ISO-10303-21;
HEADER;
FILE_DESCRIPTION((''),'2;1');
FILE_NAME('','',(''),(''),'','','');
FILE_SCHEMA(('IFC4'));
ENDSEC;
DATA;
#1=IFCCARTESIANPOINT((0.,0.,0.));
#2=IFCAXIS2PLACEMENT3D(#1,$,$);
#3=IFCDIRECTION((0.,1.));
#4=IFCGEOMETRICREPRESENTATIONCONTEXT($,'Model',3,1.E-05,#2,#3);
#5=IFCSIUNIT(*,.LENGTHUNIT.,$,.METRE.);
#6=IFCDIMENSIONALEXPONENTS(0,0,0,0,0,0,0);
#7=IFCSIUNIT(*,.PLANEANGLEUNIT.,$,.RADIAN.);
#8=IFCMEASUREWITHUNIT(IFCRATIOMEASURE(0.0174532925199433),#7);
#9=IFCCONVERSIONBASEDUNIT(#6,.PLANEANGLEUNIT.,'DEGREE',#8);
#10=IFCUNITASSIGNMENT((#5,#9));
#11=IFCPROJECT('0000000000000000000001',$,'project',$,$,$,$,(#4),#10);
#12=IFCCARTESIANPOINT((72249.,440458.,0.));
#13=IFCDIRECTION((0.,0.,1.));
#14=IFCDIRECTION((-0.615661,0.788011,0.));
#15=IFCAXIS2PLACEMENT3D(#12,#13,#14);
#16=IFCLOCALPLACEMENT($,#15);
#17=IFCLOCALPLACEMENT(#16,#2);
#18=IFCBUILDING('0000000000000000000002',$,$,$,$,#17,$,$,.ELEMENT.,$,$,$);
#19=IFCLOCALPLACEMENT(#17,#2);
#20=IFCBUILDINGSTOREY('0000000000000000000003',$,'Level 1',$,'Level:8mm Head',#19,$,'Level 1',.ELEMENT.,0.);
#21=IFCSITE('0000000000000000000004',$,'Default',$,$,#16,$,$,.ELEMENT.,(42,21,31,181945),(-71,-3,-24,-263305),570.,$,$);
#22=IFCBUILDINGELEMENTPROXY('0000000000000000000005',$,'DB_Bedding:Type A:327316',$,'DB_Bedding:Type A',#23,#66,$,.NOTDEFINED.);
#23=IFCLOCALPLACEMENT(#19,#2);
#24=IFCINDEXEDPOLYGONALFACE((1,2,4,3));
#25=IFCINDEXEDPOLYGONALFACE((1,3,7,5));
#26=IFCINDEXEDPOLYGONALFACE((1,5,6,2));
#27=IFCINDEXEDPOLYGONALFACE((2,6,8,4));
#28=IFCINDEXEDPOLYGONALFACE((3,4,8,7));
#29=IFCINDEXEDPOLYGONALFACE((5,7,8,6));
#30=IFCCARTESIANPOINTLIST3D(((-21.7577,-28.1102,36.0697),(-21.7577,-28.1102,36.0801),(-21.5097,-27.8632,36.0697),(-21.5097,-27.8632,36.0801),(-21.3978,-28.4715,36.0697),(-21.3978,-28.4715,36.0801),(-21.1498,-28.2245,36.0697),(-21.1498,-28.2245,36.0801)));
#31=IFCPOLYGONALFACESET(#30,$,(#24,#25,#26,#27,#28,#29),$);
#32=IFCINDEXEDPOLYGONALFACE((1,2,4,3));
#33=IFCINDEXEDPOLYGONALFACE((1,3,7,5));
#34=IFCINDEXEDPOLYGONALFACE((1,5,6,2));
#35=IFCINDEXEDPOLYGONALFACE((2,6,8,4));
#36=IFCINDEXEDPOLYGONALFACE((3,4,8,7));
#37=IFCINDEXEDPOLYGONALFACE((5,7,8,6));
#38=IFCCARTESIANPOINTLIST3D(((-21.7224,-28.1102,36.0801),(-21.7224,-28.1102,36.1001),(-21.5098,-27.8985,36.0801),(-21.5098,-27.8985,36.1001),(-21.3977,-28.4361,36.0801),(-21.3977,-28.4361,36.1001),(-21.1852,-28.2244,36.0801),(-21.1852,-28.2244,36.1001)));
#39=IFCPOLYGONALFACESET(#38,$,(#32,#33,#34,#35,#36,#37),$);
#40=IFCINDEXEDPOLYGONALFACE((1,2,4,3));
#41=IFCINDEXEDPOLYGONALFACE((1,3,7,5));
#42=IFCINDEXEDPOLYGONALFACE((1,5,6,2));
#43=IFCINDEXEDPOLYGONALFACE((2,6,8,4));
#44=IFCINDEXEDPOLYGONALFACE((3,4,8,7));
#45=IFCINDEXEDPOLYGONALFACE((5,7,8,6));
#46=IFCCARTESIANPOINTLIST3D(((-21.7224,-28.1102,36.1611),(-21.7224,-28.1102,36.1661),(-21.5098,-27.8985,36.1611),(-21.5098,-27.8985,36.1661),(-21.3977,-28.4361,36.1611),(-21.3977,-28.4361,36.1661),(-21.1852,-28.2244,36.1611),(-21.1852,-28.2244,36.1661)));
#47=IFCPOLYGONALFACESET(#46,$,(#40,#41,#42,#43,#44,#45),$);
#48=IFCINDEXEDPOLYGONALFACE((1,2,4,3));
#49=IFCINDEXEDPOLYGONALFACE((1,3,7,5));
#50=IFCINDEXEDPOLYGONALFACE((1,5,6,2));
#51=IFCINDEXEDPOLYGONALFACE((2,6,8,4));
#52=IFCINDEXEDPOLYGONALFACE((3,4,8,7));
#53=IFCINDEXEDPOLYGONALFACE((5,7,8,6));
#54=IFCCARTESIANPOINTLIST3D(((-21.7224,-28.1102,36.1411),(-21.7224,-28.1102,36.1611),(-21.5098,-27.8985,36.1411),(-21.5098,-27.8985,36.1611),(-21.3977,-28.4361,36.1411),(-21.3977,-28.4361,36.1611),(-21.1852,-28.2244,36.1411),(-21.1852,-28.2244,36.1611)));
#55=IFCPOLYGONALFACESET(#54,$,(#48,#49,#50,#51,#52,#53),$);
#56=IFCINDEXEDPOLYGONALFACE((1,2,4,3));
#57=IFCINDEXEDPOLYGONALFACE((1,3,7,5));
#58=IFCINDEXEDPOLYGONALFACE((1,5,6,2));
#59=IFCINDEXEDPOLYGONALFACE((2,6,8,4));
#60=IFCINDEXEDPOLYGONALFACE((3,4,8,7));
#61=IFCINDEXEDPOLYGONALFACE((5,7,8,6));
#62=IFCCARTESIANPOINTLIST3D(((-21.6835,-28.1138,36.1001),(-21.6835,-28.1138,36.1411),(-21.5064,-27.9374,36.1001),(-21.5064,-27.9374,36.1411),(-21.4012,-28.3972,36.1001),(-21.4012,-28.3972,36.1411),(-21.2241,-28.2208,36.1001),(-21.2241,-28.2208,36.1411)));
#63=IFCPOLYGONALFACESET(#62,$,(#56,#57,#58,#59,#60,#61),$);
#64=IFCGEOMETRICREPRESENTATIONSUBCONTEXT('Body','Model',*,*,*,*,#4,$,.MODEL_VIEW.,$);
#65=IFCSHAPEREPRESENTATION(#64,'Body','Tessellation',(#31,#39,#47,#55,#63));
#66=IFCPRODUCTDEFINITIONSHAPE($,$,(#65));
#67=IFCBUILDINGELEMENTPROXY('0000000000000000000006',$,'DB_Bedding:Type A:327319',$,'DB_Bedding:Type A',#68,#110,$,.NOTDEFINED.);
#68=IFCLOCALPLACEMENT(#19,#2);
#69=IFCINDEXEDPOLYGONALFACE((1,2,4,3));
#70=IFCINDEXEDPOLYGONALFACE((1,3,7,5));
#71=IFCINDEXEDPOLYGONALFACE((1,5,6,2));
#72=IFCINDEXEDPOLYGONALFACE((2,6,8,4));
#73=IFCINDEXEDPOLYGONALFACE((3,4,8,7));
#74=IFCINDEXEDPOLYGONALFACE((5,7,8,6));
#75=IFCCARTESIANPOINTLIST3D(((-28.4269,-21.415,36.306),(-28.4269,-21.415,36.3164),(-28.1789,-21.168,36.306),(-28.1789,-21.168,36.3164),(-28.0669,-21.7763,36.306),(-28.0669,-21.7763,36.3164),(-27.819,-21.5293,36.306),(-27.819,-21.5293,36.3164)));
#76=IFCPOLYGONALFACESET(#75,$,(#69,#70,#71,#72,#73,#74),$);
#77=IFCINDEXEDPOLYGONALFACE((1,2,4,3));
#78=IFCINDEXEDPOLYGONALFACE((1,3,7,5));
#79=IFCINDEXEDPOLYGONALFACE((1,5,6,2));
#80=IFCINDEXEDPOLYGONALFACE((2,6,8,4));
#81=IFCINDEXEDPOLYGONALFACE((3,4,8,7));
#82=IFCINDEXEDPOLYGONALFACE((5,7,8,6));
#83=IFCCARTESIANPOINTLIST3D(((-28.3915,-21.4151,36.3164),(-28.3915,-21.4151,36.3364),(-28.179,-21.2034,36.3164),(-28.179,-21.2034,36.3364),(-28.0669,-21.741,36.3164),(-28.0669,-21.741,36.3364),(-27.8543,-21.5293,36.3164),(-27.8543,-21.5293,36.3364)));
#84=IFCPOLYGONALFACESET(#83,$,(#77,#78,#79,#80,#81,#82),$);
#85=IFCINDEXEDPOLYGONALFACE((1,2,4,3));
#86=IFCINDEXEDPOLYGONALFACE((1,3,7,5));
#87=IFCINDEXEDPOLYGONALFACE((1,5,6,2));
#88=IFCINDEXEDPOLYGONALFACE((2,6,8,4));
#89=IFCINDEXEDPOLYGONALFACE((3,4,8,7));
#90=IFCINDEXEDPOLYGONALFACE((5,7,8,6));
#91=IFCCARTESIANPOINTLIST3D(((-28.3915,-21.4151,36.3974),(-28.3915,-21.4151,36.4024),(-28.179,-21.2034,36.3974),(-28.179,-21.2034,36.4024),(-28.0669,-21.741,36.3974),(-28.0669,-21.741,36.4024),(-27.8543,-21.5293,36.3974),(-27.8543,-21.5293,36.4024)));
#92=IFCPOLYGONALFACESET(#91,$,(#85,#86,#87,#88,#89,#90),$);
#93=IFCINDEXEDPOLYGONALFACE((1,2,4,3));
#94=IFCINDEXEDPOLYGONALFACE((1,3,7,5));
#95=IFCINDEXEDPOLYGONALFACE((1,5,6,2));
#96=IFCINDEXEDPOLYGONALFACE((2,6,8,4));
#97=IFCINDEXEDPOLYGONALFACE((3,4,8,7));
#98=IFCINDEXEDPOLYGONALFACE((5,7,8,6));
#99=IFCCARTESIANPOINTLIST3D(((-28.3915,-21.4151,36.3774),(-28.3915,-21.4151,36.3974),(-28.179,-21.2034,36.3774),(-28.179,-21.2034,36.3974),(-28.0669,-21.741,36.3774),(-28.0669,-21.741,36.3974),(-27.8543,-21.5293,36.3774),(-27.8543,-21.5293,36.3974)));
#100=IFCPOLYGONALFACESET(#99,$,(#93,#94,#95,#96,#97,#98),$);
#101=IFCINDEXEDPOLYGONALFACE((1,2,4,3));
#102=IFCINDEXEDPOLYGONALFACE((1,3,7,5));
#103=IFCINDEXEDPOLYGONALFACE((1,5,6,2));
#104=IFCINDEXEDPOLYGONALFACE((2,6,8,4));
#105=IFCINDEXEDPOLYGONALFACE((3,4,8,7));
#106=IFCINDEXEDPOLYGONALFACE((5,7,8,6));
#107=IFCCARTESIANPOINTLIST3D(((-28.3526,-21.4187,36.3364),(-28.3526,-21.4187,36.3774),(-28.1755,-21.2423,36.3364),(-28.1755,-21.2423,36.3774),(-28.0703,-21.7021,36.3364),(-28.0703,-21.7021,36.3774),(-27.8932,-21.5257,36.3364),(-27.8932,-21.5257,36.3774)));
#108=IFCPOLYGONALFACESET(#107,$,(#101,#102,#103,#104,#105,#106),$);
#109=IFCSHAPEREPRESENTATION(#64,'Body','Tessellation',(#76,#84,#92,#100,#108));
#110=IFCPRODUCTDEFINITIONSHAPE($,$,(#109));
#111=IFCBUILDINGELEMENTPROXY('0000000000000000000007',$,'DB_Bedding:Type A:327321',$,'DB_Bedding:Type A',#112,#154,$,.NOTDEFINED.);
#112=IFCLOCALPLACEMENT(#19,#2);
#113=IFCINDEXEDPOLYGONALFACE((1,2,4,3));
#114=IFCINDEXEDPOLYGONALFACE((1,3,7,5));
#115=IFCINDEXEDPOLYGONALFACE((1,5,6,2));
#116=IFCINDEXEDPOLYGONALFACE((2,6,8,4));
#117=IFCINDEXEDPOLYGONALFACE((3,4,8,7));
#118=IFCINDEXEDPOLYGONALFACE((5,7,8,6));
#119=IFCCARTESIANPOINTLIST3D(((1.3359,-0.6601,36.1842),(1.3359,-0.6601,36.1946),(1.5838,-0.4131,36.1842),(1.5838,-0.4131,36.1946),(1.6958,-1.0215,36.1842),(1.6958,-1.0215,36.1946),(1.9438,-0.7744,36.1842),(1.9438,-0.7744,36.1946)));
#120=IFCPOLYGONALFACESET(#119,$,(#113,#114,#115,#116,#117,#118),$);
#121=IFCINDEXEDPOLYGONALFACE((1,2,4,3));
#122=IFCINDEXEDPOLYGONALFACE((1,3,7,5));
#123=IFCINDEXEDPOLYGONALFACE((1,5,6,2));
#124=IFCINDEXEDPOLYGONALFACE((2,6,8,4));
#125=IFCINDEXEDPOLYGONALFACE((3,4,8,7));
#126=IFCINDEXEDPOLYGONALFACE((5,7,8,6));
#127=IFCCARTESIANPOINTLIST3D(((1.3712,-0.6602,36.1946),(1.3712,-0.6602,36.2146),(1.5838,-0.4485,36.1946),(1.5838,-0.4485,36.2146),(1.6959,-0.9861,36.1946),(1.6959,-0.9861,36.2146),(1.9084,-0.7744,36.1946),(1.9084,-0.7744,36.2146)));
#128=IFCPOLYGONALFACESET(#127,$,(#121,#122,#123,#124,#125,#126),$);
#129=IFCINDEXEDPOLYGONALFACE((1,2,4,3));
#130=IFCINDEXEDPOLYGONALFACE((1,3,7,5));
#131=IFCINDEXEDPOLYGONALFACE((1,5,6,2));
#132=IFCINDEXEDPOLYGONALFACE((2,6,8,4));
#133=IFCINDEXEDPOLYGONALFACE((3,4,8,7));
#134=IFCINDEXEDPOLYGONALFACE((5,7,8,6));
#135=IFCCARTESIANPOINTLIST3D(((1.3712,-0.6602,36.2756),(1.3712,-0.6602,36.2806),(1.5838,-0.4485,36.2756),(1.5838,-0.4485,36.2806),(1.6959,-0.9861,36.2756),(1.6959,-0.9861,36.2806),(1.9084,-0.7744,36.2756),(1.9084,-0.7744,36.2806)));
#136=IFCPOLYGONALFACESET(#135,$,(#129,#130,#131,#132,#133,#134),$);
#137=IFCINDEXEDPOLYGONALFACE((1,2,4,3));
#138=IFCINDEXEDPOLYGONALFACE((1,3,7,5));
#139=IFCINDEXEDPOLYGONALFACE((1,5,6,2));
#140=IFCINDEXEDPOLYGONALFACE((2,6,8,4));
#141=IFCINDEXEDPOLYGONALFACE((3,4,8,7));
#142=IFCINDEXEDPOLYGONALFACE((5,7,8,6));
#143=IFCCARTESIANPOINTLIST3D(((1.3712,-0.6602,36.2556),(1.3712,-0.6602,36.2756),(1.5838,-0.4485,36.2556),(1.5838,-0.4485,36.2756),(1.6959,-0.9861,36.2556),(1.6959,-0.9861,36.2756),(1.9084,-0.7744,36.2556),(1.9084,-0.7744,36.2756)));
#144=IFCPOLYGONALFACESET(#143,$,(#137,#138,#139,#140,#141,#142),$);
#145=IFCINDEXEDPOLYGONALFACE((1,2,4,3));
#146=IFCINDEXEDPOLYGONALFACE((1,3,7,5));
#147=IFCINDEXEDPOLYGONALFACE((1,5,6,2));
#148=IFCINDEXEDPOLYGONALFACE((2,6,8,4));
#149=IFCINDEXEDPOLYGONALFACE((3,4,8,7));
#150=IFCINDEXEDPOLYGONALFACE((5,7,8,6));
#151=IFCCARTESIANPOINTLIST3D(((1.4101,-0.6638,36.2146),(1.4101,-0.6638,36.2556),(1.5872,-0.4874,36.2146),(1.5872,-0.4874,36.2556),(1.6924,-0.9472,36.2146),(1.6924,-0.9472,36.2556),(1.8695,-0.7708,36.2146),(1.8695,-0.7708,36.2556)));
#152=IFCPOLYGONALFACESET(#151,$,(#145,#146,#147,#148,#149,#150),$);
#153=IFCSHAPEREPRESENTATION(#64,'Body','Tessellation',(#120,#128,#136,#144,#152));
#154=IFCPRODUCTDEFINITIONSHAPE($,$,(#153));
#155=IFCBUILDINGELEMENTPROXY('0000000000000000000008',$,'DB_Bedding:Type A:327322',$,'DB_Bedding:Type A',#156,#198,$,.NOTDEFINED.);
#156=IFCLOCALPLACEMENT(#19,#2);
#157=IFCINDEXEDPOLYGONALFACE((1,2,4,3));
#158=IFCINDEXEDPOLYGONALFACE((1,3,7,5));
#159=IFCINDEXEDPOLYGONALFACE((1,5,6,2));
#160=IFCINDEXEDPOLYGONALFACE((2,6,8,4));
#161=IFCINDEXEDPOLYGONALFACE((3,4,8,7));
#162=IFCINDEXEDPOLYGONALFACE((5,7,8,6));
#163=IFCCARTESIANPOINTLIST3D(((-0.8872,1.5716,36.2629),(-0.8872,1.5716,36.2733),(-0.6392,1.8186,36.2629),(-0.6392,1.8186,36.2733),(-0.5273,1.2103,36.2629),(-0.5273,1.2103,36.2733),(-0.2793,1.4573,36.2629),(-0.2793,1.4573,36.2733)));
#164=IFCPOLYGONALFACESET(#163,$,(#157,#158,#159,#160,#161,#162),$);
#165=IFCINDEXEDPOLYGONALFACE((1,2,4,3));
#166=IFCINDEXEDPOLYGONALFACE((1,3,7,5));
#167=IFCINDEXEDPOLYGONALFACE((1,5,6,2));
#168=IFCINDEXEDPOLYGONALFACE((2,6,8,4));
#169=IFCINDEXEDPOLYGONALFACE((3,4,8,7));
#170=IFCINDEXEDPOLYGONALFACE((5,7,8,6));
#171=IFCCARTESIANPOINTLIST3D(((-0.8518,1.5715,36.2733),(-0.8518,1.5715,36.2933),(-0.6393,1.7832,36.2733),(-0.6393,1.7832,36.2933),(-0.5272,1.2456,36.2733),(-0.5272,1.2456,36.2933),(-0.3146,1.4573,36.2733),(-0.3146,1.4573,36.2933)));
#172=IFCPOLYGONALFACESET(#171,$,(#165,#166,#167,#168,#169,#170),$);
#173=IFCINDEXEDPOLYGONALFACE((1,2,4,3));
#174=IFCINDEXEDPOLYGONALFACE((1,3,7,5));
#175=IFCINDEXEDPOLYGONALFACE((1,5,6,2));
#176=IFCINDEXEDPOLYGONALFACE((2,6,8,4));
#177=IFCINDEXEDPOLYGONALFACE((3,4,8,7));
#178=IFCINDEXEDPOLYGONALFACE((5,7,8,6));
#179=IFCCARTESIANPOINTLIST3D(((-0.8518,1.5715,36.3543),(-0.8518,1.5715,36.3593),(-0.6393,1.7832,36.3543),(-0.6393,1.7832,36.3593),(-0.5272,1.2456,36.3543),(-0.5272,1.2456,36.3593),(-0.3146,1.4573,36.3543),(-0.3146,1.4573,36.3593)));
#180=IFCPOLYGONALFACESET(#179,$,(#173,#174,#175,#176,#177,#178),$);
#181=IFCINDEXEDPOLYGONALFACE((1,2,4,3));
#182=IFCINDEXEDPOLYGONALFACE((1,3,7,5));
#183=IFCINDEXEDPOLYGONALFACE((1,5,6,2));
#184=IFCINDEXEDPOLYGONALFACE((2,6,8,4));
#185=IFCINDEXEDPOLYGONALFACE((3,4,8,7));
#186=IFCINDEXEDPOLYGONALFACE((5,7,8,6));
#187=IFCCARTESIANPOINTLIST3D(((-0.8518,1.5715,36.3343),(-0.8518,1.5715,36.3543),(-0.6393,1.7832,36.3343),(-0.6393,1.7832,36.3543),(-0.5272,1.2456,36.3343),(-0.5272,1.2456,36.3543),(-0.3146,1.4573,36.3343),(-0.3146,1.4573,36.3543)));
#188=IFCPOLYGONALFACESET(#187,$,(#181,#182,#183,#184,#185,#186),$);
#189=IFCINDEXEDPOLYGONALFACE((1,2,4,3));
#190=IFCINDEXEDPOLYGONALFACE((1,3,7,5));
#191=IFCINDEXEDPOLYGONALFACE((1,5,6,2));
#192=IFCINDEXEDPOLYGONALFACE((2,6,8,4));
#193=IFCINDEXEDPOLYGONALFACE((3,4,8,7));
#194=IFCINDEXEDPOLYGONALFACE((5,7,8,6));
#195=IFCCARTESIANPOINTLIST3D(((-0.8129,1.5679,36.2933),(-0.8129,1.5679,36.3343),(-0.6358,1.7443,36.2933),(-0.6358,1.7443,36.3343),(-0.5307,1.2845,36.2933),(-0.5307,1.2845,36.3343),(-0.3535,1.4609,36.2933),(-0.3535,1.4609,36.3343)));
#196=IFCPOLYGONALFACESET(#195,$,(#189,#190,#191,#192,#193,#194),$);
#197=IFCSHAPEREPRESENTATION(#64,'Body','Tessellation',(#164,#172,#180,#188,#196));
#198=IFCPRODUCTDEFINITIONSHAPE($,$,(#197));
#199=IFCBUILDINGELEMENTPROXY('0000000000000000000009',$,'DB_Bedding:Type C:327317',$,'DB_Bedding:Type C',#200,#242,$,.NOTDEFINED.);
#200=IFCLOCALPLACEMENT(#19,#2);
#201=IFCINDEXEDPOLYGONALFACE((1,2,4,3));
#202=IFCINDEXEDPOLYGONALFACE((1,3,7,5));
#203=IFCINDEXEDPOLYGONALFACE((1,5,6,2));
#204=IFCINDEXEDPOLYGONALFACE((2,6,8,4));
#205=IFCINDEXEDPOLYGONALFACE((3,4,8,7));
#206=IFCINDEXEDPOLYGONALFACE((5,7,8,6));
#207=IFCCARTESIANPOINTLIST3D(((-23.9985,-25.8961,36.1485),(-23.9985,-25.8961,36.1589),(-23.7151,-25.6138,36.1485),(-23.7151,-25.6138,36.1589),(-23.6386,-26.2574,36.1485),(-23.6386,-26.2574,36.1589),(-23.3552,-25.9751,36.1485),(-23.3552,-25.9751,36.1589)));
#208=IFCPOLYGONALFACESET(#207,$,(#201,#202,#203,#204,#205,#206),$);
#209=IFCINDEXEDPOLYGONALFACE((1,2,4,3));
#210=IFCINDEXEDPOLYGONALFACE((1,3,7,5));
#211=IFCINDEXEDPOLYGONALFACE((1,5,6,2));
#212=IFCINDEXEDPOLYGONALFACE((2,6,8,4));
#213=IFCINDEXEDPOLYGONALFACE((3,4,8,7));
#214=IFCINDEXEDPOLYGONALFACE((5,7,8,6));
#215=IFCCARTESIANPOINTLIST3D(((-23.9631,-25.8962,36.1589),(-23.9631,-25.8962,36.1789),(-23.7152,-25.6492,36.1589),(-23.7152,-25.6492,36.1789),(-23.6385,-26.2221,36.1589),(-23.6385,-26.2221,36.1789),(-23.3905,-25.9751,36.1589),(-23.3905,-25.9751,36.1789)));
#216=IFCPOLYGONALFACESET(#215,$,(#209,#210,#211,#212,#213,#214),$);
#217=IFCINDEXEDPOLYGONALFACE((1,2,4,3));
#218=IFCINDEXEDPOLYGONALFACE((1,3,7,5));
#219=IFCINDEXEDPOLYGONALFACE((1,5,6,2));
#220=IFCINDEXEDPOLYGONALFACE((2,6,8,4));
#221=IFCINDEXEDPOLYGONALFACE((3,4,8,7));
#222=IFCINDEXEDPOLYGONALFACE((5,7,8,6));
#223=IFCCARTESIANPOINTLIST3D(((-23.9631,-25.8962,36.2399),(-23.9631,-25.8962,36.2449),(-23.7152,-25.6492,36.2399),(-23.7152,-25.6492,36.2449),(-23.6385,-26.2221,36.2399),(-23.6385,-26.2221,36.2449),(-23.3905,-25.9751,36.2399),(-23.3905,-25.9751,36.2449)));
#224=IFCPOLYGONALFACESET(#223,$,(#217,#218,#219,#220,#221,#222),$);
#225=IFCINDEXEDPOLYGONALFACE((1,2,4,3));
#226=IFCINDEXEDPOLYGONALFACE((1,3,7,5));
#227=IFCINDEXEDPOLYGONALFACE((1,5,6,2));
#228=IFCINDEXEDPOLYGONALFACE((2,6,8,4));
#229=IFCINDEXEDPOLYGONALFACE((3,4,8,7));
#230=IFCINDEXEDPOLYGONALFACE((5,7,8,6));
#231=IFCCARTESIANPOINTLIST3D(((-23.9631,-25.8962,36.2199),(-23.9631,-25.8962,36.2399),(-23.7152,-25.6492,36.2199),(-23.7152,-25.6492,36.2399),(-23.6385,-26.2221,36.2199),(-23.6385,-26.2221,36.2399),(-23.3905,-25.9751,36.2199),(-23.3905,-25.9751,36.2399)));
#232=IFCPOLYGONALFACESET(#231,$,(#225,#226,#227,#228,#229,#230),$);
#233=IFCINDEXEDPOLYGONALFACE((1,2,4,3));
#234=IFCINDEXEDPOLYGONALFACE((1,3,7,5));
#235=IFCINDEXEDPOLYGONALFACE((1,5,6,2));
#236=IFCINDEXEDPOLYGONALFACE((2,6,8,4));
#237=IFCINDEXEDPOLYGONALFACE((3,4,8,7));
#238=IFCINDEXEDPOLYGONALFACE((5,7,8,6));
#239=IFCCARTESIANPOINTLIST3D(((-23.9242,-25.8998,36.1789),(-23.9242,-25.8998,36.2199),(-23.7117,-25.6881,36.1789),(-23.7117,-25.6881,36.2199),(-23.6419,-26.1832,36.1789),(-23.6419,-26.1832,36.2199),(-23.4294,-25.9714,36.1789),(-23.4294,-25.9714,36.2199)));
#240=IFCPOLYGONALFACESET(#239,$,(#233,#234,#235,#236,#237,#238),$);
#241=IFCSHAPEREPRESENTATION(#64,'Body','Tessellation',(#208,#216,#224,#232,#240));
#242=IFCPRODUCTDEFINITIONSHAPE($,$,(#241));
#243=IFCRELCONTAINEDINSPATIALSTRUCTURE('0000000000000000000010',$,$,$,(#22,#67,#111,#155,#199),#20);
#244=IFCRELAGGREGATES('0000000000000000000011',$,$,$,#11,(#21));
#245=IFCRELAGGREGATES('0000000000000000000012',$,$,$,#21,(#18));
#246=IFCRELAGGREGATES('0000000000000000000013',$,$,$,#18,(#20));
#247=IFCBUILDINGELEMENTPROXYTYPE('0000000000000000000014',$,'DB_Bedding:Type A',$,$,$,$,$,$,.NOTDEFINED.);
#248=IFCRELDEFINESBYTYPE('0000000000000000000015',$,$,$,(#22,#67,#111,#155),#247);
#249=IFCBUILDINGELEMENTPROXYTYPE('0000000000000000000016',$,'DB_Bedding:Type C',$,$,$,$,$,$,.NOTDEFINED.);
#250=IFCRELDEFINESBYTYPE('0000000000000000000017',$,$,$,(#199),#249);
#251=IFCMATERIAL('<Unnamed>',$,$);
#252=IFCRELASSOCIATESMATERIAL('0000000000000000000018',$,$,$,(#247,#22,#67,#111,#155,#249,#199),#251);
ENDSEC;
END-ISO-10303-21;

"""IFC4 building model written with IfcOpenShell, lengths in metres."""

from ifc_helpers import new_model, entity, si_unit, converted_unit, direction, frame, origin, origin_2d_with_axis, place, context, subcontext, project, spatial, rectangle, extrude, source, transform, mapped, material, type_object, type_shapes, element, save


model = new_model("IFC4")

# Units and contexts
model_context = context("Model", 3, precision=1e-05, world=origin(), true_north=direction((0.0, 1.0)))
body_context = subcontext(model_context, "Body", "Model", "MODEL_VIEW")
ifc_project = project(units=[si_unit("LENGTHUNIT", "METRE"), converted_unit("PLANEANGLEUNIT", "DEGREE", entity("IfcRatioMeasure", 0.0174532925199433), si_unit("PLANEANGLEUNIT", "RADIAN"), dimensions=[0, 0, 0, 0, 0, 0, 0])], contexts=[model_context])

# Site, building, storey
site_placement = place(None, frame((72249.0, 440458.0, 0.0), z_axis=(0.0, 0.0, 1.0), x_axis=(-0.615661, 0.788011, 0.0)))
site = spatial("IfcSite", under=ifc_project, at=site_placement, Name="Default", CompositionType="ELEMENT", RefLatitude=(42, 21, 31, 181945), RefLongitude=(-71, -3, -24, -263305), RefElevation=570.0)
building_placement = place(site_placement, origin())
building = spatial("IfcBuilding", under=site, at=building_placement, CompositionType="ELEMENT")
storey_placement = place(building_placement, origin())
storey = spatial("IfcBuildingStorey", under=building, at=storey_placement, Name="Level 1", ObjectType="Level:8mm Head", LongName="Level 1", CompositionType="ELEMENT", Elevation=0.0)

# Building element proxies
ifc_material = material(Name="<Unnamed>")
building_element_proxy_type_1 = type_object("IfcBuildingElementProxyType", Name="DB_Bedding:Type A", PredefinedType="NOTDEFINED", material=ifc_material)
shared_shape_1 = source(origin(), body_context, "Body", "SweptSolid", [
    extrude(rectangle(XDim=0.35, YDim=0.51, at=origin_2d_with_axis()), frame((0.0, 0.0, -0.0965), z_axis=(0.0, 0.0, 1.0), x_axis=(0.0, 1.0, 0.0)), (0.0, 0.0, 1.0), 0.0105),
    extrude(rectangle(XDim=0.3, YDim=0.46, at=origin_2d_with_axis()), frame((0.0, 0.0, -0.086), z_axis=(0.0, 0.0, 1.0), x_axis=(0.0, 1.0, 0.0)), (0.0, 0.0, 1.0), 0.02),
    extrude(rectangle(XDim=0.3, YDim=0.46, at=origin_2d_with_axis()), frame((0.0, 0.0, -0.005), z_axis=(0.0, 0.0, 1.0), x_axis=(0.0, 1.0, 0.0)), (0.0, 0.0, 1.0), 0.005),
    extrude(rectangle(XDim=0.3, YDim=0.46, at=origin_2d_with_axis()), frame((0.0, 0.0, -0.025), z_axis=(0.0, 0.0, 1.0), x_axis=(0.0, 1.0, 0.0)), (0.0, 0.0, 1.0), 0.02),
    extrude(rectangle(XDim=0.25, YDim=0.4, at=origin_2d_with_axis()), frame((0.0, 0.0, -0.066), z_axis=(0.0, 0.0, 1.0), x_axis=(0.0, 1.0, 0.0)), (0.0, 0.0, 1.0), 0.041),
])
type_shapes(building_element_proxy_type_1, [shared_shape_1])
for number, where, z_axis, x_axis, name in (
    (1, (-21.4538, -28.1673, 36.1661), (0.0, 0.0, 1.0), (0.70573, -0.708481, 0.0), "DB_Bedding:Type A:327316"),
    (2, (-28.1229, -21.4722, 36.4024), (0.0, 0.0, 1.0), (0.70573, -0.708481, 0.0), "DB_Bedding:Type A:327319"),
    (3, (1.6398, -0.7173, 36.2806), (0.0, 0.0, 1.0), (0.70573, -0.708481, 0.0), "DB_Bedding:Type A:327321"),
    (4, (-0.5832, 1.5144, 36.3593), (0.0, 0.0, 1.0), (0.70573, -0.708481, 0.0), "DB_Bedding:Type A:327322"),
):
    element("IfcBuildingElementProxy", number, at=place(storey_placement, frame(where, z_axis=z_axis, x_axis=x_axis)), inside=storey, type_object=building_element_proxy_type_1, material=ifc_material, Name=name, ObjectType="DB_Bedding:Type A", PredefinedType="NOTDEFINED", context=body_context, shape_type="MappedRepresentation", body=[
        mapped(shared_shape_1, transform((0.0, 0.0, 0.0), scale=1.0)),
    ])
building_element_proxy_type_2 = type_object("IfcBuildingElementProxyType", Name="DB_Bedding:Type C", PredefinedType="NOTDEFINED", material=ifc_material)
shared_shape_2 = source(origin(), body_context, "Body", "SweptSolid", [
    extrude(rectangle(XDim=0.4, YDim=0.51, at=origin_2d_with_axis()), frame((0.0, 0.0, -0.0965), z_axis=(0.0, 0.0, 1.0), x_axis=(0.0, 1.0, 0.0)), (0.0, 0.0, 1.0), 0.0105),
    extrude(rectangle(XDim=0.35, YDim=0.46, at=origin_2d_with_axis()), frame((0.0, 0.0, -0.086), z_axis=(0.0, 0.0, 1.0), x_axis=(0.0, 1.0, 0.0)), (0.0, 0.0, 1.0), 0.02),
    extrude(rectangle(XDim=0.35, YDim=0.46, at=origin_2d_with_axis()), frame((0.0, 0.0, -0.005), z_axis=(0.0, 0.0, 1.0), x_axis=(0.0, 1.0, 0.0)), (0.0, 0.0, 1.0), 0.005),
    extrude(rectangle(XDim=0.35, YDim=0.46, at=origin_2d_with_axis()), frame((0.0, 0.0, -0.025), z_axis=(0.0, 0.0, 1.0), x_axis=(0.0, 1.0, 0.0)), (0.0, 0.0, 1.0), 0.02),
    extrude(rectangle(XDim=0.3, YDim=0.4, at=origin_2d_with_axis()), frame((0.0, 0.0, -0.066), z_axis=(0.0, 0.0, 1.0), x_axis=(0.0, 1.0, 0.0)), (0.0, 0.0, 1.0), 0.041),
])
type_shapes(building_element_proxy_type_2, [shared_shape_2])
for number, where, z_axis, x_axis, name in (
    (5, (-23.6768, -25.9356, 36.2449), (0.0, 0.0, 1.0), (0.70573, -0.708481, 0.0), "DB_Bedding:Type C:327317"),
):
    element("IfcBuildingElementProxy", number, at=place(storey_placement, frame(where, z_axis=z_axis, x_axis=x_axis)), inside=storey, type_object=building_element_proxy_type_2, material=ifc_material, Name=name, ObjectType="DB_Bedding:Type C", PredefinedType="NOTDEFINED", context=body_context, shape_type="MappedRepresentation", body=[
        mapped(shared_shape_2, transform((0.0, 0.0, 0.0), scale=1.0)),
    ])

save(model, "model.ifc")
